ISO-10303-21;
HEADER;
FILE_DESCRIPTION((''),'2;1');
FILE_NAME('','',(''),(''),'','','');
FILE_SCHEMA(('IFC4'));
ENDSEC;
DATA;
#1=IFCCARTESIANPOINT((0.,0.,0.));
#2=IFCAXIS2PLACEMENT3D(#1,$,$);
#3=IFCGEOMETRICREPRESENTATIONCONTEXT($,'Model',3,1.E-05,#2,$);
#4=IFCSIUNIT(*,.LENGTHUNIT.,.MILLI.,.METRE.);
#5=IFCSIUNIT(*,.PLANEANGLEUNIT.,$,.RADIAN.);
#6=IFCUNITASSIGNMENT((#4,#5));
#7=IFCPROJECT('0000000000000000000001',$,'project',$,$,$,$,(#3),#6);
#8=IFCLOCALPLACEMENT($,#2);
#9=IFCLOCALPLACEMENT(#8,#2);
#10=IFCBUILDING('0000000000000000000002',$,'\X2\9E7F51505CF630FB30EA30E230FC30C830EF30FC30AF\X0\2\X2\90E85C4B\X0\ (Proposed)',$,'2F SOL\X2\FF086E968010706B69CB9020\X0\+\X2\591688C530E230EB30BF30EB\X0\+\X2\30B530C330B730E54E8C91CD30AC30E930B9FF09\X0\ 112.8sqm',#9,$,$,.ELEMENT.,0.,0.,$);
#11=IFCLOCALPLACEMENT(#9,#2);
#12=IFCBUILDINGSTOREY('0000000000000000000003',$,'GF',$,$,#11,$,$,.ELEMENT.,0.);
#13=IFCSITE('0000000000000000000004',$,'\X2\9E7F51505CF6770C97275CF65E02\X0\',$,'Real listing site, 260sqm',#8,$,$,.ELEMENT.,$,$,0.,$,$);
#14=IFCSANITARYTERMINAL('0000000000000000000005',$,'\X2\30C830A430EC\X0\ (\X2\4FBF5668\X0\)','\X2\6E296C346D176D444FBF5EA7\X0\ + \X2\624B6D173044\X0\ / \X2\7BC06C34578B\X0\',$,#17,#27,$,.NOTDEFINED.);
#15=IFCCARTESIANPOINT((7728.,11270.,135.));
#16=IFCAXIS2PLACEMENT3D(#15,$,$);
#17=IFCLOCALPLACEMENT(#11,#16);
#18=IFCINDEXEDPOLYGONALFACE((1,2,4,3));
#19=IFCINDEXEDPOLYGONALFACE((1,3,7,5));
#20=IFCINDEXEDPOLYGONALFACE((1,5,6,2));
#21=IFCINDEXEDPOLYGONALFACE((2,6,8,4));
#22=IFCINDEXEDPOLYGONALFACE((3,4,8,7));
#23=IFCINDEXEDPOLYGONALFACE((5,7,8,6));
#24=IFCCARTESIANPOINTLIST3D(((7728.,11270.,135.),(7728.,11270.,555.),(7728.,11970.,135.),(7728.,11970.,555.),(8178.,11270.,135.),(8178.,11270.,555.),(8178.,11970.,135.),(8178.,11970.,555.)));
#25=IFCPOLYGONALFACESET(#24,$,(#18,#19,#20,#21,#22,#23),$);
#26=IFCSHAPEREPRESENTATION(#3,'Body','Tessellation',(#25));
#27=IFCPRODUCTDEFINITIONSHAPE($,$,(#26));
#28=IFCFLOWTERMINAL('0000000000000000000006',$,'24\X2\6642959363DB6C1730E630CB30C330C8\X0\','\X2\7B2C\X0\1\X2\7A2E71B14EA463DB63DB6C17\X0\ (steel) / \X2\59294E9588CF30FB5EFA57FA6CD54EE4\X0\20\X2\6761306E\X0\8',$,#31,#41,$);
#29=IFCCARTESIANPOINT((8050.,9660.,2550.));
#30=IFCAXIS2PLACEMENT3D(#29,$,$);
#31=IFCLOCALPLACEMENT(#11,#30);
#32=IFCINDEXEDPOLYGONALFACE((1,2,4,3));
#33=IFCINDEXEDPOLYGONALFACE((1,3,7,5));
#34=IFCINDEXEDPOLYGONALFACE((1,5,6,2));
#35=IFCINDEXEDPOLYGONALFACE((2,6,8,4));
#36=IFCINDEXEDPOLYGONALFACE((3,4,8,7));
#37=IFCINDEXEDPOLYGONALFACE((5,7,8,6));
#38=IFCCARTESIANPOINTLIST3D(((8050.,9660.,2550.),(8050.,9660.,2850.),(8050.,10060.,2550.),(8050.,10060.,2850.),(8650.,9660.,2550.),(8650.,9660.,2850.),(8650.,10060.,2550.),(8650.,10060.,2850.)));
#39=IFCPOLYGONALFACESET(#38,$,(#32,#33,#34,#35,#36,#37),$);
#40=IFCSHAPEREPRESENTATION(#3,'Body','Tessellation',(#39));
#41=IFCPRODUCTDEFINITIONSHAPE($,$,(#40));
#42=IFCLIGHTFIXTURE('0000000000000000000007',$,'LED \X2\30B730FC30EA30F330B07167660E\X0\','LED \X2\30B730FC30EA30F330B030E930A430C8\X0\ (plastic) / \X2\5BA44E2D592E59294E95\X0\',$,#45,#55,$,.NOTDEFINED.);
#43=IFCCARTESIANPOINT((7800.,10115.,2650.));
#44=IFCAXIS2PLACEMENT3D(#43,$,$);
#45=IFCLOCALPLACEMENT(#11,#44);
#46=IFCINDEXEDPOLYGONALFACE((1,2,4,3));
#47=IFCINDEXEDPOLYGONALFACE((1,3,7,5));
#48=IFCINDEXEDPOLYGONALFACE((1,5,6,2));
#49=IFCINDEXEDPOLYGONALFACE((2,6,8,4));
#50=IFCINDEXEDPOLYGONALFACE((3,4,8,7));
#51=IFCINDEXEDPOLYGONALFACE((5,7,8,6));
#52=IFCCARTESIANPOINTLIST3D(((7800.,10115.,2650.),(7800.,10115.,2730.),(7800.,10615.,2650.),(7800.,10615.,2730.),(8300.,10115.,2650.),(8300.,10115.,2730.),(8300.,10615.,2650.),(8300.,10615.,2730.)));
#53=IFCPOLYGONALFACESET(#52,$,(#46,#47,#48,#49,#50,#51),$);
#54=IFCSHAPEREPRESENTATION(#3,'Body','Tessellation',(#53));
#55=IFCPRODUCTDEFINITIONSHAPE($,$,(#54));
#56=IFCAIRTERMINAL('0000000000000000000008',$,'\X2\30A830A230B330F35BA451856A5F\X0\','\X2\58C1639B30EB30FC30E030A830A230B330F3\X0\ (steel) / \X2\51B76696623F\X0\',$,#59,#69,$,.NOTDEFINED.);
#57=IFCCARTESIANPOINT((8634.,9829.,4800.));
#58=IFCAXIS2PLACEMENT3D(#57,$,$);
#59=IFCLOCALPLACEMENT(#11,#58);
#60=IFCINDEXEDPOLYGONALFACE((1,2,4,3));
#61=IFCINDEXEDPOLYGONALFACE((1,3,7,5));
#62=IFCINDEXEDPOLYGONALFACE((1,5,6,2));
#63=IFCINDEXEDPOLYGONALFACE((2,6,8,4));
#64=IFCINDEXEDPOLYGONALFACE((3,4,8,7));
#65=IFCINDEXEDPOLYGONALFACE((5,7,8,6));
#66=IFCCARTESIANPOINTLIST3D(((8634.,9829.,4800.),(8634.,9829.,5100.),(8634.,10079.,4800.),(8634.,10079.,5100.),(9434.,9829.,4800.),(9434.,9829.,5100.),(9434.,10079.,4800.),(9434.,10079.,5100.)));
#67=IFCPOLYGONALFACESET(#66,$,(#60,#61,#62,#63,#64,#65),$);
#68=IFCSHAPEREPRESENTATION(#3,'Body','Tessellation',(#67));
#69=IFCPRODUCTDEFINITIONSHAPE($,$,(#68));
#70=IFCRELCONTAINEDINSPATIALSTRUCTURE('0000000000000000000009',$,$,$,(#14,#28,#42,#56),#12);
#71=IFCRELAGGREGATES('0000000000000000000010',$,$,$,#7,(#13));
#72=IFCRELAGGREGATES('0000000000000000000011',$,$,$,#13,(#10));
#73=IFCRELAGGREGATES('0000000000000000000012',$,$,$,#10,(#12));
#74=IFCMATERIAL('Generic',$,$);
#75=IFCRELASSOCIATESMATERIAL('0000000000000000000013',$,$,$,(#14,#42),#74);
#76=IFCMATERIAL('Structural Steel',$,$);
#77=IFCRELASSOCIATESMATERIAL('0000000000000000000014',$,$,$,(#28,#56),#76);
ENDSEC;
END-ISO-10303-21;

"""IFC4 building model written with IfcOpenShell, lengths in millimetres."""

from ifc_helpers import new_model, si_unit, frame, frame_2d, origin, place, context, project, spatial, rectangle, extrude, material, element, save


model = new_model("IFC4")

# Units and contexts
model_context = context("Model", 3, precision=1e-05, world=origin())
ifc_project = project(units=[si_unit("LENGTHUNIT", "METRE", prefix="MILLI"), si_unit("PLANEANGLEUNIT", "RADIAN")], contexts=[model_context])

# Site, building, storey
site_placement = place(None, origin())
site = spatial("IfcSite", under=ifc_project, at=site_placement, Name="鹿児島県霧島市", ObjectType="Real listing site, 260sqm", CompositionType="ELEMENT", RefElevation=0.0)
building_placement = place(site_placement, origin())
building = spatial("IfcBuilding", under=site, at=building_placement, Name="鹿児島・リモートワーク2部屋 (Proposed)", ObjectType="2F SOL（準耐火構造+外装モルタル+サッシュ二重ガラス） 112.8sqm", CompositionType="ELEMENT", ElevationOfRefHeight=0.0, ElevationOfTerrain=0.0)
storey_placement = place(building_placement, origin())
storey = spatial("IfcBuildingStorey", under=building, at=storey_placement, Name="GF", CompositionType="ELEMENT", Elevation=0.0)

# Sanitary terminal
ifc_material_1 = material(Name="Generic")
sanitary_terminal_placement = place(storey_placement, frame((7728.0, 11270.0, 135.0)))
element("IfcSanitaryTerminal", 1, at=sanitary_terminal_placement, inside=storey, material=ifc_material_1, Name="トイレ (便器)", Description="温水洗浄便座 + 手洗い / 節水型", PredefinedType="NOTDEFINED", context=model_context, shape_type="SweptSolid", body=[
    extrude(rectangle(XDim=450.0, YDim=700.0, at=frame_2d((225.0, 350.0))), frame((7728.0, 11270.0, 135.0)), (0.0, 0.0, 1.0), 420.0),
])

# Flow terminal
ifc_material_2 = material(Name="Structural Steel")
flow_terminal_placement = place(storey_placement, frame((8050.0, 9660.0, 2550.0)))
element("IfcFlowTerminal", 2, at=flow_terminal_placement, inside=storey, material=ifc_material_2, Name="24時間換気ユニット", Description="第1種熱交換換気 (steel) / 天井裏・建基法令20条の8", context=model_context, shape_type="SweptSolid", body=[
    extrude(rectangle(XDim=600.0, YDim=400.0, at=frame_2d((300.0, 200.0))), frame((8050.0, 9660.0, 2550.0)), (0.0, 0.0, 1.0), 300.0),
])

# Light fixture
light_fixture_placement = place(storey_placement, frame((7800.0, 10115.0, 2650.0)))
element("IfcLightFixture", 3, at=light_fixture_placement, inside=storey, material=ifc_material_1, Name="LED シーリング照明", Description="LED シーリングライト (plastic) / 室中央天井", PredefinedType="NOTDEFINED", context=model_context, shape_type="SweptSolid", body=[
    extrude(rectangle(XDim=500.0, YDim=500.0, at=frame_2d((250.0, 250.0))), frame((7800.0, 10115.0, 2650.0)), (0.0, 0.0, 1.0), 80.0),
])

# Air terminal
air_terminal_placement = place(storey_placement, frame((8634.0, 9829.0, 4800.0)))
element("IfcAirTerminal", 4, at=air_terminal_placement, inside=storey, material=ifc_material_2, Name="エアコン室内機", Description="壁掛ルームエアコン (steel) / 冷暖房", PredefinedType="NOTDEFINED", context=model_context, shape_type="SweptSolid", body=[
    extrude(rectangle(XDim=800.0, YDim=250.0, at=frame_2d((400.0, 125.0))), frame((8634.0, 9829.0, 4800.0)), (0.0, 0.0, 1.0), 300.0),
])

save(model, "model.ifc")
